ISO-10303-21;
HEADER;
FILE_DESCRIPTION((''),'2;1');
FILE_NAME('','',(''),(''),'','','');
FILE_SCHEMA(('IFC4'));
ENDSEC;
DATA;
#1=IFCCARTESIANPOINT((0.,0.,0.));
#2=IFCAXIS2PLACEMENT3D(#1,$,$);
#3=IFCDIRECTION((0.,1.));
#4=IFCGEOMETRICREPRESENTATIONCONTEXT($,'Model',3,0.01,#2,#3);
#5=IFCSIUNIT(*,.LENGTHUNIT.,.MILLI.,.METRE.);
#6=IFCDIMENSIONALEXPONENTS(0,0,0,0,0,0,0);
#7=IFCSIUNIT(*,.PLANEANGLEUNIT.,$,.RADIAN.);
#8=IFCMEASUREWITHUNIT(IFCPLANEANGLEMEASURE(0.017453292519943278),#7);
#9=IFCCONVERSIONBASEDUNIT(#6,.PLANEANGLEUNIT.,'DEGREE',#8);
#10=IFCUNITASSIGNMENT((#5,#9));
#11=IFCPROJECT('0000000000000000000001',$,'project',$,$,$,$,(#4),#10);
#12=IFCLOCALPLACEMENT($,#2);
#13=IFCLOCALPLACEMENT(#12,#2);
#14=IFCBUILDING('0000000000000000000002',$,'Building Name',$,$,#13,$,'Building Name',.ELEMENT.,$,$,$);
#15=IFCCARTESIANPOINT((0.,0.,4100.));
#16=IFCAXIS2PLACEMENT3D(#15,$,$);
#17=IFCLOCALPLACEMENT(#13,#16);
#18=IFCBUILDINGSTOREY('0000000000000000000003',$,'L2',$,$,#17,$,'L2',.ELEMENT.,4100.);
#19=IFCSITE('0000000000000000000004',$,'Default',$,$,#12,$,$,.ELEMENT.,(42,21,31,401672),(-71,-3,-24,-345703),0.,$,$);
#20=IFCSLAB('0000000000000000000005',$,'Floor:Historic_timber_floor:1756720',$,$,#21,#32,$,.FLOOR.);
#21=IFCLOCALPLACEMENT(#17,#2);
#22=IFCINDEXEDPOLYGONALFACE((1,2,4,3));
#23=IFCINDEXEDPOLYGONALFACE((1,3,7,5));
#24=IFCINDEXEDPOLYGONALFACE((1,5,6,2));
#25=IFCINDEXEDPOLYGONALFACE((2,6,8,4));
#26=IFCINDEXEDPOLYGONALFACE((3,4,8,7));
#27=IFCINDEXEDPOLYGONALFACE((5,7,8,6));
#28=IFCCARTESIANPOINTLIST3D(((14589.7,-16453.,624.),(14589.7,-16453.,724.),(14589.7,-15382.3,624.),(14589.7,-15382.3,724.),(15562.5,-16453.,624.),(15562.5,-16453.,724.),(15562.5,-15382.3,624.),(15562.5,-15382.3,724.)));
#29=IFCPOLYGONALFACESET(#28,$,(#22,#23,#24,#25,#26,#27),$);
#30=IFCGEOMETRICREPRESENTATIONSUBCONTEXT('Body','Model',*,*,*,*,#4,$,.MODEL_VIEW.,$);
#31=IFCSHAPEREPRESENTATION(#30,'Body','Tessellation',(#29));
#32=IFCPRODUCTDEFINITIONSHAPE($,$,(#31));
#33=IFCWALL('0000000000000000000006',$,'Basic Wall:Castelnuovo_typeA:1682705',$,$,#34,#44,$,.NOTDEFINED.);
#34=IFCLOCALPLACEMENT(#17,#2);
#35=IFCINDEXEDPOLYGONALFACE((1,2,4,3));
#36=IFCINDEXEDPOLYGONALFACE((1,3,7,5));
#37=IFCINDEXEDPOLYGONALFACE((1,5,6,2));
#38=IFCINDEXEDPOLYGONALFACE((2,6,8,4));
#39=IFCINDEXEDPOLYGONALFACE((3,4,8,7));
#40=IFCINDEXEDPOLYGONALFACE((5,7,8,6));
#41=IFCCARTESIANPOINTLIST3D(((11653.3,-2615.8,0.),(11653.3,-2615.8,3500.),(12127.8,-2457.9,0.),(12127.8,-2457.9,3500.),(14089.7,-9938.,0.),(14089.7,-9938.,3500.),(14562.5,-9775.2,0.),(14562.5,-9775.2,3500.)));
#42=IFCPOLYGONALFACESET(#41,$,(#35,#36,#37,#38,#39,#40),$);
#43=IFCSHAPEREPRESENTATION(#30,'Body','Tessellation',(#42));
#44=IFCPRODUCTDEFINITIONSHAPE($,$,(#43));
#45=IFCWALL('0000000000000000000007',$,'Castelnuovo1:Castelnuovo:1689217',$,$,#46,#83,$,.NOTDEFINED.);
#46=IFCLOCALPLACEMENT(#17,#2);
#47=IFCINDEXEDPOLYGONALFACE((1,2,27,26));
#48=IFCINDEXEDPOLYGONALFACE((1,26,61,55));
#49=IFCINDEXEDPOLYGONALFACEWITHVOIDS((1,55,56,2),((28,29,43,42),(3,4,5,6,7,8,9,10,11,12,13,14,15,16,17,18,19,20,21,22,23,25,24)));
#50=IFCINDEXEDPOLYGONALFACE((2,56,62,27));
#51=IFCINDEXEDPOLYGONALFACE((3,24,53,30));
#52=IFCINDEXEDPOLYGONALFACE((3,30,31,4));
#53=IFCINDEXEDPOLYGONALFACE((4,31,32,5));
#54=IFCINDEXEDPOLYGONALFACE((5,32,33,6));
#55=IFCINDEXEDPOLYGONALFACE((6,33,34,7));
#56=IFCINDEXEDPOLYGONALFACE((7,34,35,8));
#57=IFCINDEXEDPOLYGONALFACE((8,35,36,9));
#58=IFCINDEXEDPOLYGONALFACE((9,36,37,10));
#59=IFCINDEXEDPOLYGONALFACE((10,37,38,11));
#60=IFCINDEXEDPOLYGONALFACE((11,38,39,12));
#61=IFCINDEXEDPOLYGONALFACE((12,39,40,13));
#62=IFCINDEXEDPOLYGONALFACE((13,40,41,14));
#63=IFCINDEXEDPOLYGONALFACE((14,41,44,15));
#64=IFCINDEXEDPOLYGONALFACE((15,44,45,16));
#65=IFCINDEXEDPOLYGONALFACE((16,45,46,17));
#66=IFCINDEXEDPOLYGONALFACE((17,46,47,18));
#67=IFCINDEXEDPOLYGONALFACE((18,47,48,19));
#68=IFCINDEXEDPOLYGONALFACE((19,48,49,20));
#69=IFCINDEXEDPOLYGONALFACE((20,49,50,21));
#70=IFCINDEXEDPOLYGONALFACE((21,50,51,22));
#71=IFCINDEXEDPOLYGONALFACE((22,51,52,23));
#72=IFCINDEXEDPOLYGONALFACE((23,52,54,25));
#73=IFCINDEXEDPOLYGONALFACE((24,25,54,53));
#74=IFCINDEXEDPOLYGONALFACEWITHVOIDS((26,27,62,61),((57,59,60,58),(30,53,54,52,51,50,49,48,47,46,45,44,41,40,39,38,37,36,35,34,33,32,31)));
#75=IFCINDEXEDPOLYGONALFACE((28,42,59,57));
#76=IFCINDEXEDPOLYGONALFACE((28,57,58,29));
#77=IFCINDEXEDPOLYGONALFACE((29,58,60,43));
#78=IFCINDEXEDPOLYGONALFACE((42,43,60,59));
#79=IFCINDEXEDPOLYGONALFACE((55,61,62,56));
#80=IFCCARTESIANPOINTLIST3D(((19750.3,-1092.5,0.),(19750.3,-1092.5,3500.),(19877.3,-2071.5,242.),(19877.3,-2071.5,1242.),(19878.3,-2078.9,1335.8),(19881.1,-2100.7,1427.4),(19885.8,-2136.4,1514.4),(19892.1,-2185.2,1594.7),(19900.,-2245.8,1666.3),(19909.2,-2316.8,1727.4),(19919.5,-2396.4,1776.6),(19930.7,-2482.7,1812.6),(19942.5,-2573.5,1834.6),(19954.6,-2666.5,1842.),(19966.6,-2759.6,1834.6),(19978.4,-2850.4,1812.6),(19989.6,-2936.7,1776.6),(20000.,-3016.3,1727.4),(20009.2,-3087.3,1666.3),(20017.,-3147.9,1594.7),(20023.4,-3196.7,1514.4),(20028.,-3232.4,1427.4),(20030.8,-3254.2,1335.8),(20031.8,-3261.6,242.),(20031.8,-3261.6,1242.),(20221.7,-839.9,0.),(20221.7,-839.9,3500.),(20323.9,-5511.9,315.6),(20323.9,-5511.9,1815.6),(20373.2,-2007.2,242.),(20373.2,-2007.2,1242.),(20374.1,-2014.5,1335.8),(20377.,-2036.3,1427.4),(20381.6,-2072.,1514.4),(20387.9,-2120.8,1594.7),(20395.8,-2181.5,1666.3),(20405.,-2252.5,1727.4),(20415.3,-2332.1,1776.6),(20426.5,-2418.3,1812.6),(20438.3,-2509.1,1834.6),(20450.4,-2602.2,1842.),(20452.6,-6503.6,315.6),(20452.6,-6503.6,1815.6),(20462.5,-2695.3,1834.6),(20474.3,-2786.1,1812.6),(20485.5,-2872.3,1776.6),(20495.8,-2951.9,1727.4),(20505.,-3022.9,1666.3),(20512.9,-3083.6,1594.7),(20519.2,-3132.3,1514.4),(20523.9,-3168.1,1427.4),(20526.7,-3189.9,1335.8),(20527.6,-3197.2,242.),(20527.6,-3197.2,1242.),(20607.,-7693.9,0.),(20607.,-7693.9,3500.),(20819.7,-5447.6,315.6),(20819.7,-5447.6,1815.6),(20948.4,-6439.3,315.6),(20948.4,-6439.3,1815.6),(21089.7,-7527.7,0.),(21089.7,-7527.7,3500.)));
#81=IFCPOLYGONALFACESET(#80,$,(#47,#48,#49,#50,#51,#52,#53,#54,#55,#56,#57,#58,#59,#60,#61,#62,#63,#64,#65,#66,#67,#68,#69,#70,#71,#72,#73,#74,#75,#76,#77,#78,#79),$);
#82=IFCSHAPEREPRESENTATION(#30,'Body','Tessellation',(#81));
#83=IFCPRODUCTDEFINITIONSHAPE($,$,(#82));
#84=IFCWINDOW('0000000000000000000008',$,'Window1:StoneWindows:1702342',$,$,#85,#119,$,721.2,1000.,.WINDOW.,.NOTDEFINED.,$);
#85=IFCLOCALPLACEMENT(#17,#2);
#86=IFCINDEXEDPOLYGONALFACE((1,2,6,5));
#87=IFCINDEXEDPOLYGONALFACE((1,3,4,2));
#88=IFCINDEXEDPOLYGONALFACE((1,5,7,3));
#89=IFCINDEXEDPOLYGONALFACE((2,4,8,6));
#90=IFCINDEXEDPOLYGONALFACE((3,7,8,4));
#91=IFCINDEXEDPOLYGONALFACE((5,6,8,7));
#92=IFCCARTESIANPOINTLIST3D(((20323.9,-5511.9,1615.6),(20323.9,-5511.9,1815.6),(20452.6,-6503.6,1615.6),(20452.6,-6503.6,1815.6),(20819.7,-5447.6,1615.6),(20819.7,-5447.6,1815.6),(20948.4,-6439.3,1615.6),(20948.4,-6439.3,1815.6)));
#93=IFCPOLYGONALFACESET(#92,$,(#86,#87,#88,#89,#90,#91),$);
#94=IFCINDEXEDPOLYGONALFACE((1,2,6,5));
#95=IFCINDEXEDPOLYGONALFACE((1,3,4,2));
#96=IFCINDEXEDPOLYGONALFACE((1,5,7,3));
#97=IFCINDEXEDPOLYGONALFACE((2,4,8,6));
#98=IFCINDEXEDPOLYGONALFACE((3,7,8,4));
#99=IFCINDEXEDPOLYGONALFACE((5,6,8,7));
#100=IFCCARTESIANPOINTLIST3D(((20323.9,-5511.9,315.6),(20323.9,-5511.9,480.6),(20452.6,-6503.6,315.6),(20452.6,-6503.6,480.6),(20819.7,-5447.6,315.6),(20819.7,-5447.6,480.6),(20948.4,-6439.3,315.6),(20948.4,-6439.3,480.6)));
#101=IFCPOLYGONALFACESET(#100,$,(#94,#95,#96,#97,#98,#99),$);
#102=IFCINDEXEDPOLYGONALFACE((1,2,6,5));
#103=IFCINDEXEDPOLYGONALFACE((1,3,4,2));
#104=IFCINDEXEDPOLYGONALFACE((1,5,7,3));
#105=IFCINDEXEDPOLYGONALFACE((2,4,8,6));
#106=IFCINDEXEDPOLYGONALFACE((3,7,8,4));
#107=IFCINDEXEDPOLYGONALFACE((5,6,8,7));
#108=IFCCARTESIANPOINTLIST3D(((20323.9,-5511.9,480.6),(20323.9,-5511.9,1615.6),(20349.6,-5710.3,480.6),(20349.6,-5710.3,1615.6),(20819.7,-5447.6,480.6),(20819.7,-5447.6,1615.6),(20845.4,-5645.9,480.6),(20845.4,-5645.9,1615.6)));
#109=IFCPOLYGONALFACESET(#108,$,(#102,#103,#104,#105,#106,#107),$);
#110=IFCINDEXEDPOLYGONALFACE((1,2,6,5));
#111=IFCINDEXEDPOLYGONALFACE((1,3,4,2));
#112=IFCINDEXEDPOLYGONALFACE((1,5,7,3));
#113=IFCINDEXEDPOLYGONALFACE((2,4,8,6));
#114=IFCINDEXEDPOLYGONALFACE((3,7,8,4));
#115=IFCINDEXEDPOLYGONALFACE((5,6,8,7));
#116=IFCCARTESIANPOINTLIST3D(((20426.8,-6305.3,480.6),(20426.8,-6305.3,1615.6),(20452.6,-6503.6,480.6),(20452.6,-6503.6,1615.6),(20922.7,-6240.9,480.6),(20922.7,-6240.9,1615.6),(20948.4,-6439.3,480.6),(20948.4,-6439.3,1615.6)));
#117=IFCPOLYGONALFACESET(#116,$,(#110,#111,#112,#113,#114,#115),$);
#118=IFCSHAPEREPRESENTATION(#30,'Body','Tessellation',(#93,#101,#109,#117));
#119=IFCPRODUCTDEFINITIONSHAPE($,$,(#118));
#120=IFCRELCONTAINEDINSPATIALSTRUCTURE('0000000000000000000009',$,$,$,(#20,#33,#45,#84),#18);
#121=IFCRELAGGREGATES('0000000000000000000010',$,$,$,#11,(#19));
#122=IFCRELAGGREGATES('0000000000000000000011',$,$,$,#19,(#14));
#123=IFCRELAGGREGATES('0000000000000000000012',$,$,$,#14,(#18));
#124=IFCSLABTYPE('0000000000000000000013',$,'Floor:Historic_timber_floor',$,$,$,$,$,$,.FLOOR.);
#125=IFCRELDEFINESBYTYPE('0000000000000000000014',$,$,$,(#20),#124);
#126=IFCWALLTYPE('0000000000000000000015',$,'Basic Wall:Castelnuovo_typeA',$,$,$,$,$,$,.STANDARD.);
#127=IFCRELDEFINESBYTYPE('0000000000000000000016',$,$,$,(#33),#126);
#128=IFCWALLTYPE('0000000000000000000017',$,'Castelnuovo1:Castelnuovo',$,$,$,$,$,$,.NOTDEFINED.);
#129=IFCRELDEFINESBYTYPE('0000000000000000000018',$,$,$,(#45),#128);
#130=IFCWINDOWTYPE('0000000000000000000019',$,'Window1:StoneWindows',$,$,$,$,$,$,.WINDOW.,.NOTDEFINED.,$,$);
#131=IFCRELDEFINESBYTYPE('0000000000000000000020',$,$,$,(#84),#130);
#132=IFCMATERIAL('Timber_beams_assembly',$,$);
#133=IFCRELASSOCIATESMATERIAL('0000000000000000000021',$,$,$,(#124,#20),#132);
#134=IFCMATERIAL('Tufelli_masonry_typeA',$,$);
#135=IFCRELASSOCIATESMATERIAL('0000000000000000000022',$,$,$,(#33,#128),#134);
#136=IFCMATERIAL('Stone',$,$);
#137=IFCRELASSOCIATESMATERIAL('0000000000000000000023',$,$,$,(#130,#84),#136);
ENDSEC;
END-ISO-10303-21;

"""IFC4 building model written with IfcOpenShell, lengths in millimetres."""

from ifc_helpers import new_model, entity, si_unit, converted_unit, direction, frame, origin, place, context, subcontext, project, spatial, line, arc, indexed_curve, outline, extrude, source, transform, mapped, material, type_object, type_shapes, element, save


model = new_model("IFC4")

# Units and contexts
model_context = context("Model", 3, precision=0.01, world=origin(), true_north=direction((0.0, 1.0)))
body_context = subcontext(model_context, "Body", "Model", "MODEL_VIEW")
ifc_project = project(units=[si_unit("LENGTHUNIT", "METRE", prefix="MILLI"), converted_unit("PLANEANGLEUNIT", "DEGREE", entity("IfcPlaneAngleMeasure", 0.017453292519943278), si_unit("PLANEANGLEUNIT", "RADIAN"), dimensions=[0, 0, 0, 0, 0, 0, 0])], contexts=[model_context])

# Site, building, storey
site_placement = place(None, origin())
site = spatial("IfcSite", under=ifc_project, at=site_placement, Name="Default", CompositionType="ELEMENT", RefLatitude=(42, 21, 31, 401672), RefLongitude=(-71, -3, -24, -345703), RefElevation=0.0)
building_placement = place(site_placement, origin())
building = spatial("IfcBuilding", under=site, at=building_placement, Name="Building Name", LongName="Building Name", CompositionType="ELEMENT")
storey_placement = place(building_placement, frame((0.0, 0.0, 4100.0)))
storey = spatial("IfcBuildingStorey", under=building, at=storey_placement, Name="L2", LongName="L2", CompositionType="ELEMENT", Elevation=4100.0)

# Slab
ifc_material_1 = material(Name="Timber_beams_assembly")
slab_type = type_object("IfcSlabType", Name="Floor:Historic_timber_floor", PredefinedType="FLOOR", material=ifc_material_1)
slab_1_placement = place(storey_placement, origin())
element("IfcSlab", 1, at=slab_1_placement, inside=storey, type_object=slab_type, material=ifc_material_1, Name="Floor:Historic_timber_floor:1756720", PredefinedType="FLOOR", context=body_context, shape_type="SweptSolid", body=[
    extrude(outline(indexed_curve([(-535.3, -486.4), (535.3, -486.4), (535.3, 486.4), (-535.3, 486.4), (-535.3, -486.4)], self_intersect=False)), frame((15076.1, -15917.7, 724.0), z_axis=(0.0, 0.0, -1.0), x_axis=(0.0, 1.0, 0.0)), (0.0, 0.0, 1.0), 100.0),
])

# Wall
ifc_material_2 = material(Name="Tufelli_masonry_typeA")
wall_type_1 = type_object("IfcWallType", Name="Basic Wall:Castelnuovo_typeA", PredefinedType="STANDARD")
wall_1_placement = place(storey_placement, frame((11890.5, -2536.8, 0.0), z_axis=(0.0, 0.0, 1.0), x_axis=(0.315716, -0.948854, 0.0)))
element("IfcWall", 2, at=wall_1_placement, inside=storey, type_object=wall_type_1, material=ifc_material_2, Name="Basic Wall:Castelnuovo_typeA:1682705", PredefinedType="NOTDEFINED", context=body_context, shape_type="SweptSolid", body=[
    extrude(outline(indexed_curve([(7716.9, -250.0), (7711.7, 250.0), (0.0, 250.0), (0.0, -250.0), (7716.9, -250.0)], self_intersect=False)), origin(), (0.0, 0.0, 1.0), 3500.0),
])

# Wall, openings
wall_type_2 = type_object("IfcWallType", Name="Castelnuovo1:Castelnuovo", PredefinedType="NOTDEFINED", material=ifc_material_2)
wall_2_placement = place(storey_placement, frame((19750.3, -7693.9, 0.0), z_axis=(0.0, 0.0, 1.0), x_axis=(0.0, 1.0, 0.0)))
wall_2 = element("IfcWall", 3, at=wall_2_placement, inside=storey, type_object=wall_type_2, Name="Castelnuovo1:Castelnuovo:1689217", PredefinedType="NOTDEFINED", context=body_context, shape_type="SweptSolid", body=[
    extrude(outline(indexed_curve([(-929.1, -3281.7), (-418.7, -3281.7), (937.9, 3324.4), (409.9, 3239.0), (-929.1, -3281.7)], self_intersect=False)), frame((3405.4, -666.9, 0.0), z_axis=(0.0, 0.0, 1.0), x_axis=(0.325568, -0.945519, 0.0)), (0.0, 0.0, 1.0), 3500.0),
])
opening_1_placement = place(wall_2_placement, origin())
element("IfcOpeningElement", 4, at=opening_1_placement, cuts=wall_2, PredefinedType="OPENING", context=body_context, shape_type="SweptSolid", body=[
    extrude(outline(indexed_curve([(-750.0, -500.0), (750.0, -500.0), (750.0, 500.0), (-750.0, 500.0), (-750.0, -500.0)], self_intersect=False)), frame((1683.5, -618.1, 1065.6), z_axis=(0.128709, -0.991682, 0.0), x_axis=(0.0, 0.0, 1.0)), (0.0, 0.0, 1.0), 590.0),
])
opening_2_placement = place(wall_2_placement, origin())
element("IfcOpeningElement", 5, at=opening_2_placement, cuts=wall_2, PredefinedType="OPENING", context=body_context, shape_type="SweptSolid", body=[
    extrude(outline(indexed_curve([(-750.0, -500.0), (750.0, -500.0), (750.0, 500.0), (-750.0, 500.0), (-750.0, -500.0)], self_intersect=False)), frame((1753.0, -1153.6, 1065.6), z_axis=(-0.128709, 0.991682, 0.0), x_axis=(0.0, 0.0, 1.0)), (0.0, 0.0, 1.0), 590.0),
])
opening_3_placement = place(wall_2_placement, origin())
element("IfcOpeningElement", 6, at=opening_3_placement, cuts=wall_2, PredefinedType="OPENING", context=body_context, shape_type="SweptSolid", body=[
    extrude(outline(indexed_curve([(-750.0, -500.0), (750.0, -500.0), (750.0, 500.0), (-750.0, 500.0), (-750.0, -500.0)], self_intersect=False)), frame((1683.5, -618.1, 1065.6), z_axis=(0.128709, -0.991682, 0.0), x_axis=(0.0, 0.0, 1.0)), (0.0, 0.0, 1.0), 590.0),
])
opening_4_placement = place(wall_2_placement, origin())
element("IfcOpeningElement", 7, at=opening_4_placement, cuts=wall_2, PredefinedType="OPENING", context=body_context, shape_type="SweptSolid", body=[
    extrude(outline(indexed_curve([(-500.0, -600.0), (500.0, -600.0), (1100.0, 0.0), (500.0, 600.0), (-500.0, 600.0)], segments=[line(1, 2), arc(2, 3, 4), line(4, 5, 1)], self_intersect=False)), frame((5024.7, -184.5, 742.0), z_axis=(0.128709, -0.991682, 0.0), x_axis=(0.0, 0.0, 1.0)), (0.0, 0.0, 1.0), 590.0),
])

# Window
ifc_material_3 = material(Name="Stone")
window_type_1 = type_object("IfcWindowType", Name="Window1:StoneWindows", PartitioningType="NOTDEFINED", PredefinedType="WINDOW", material=ifc_material_3)
shared_shape_1 = source(origin(), body_context, "Body", "SweptSolid", [
    extrude(outline(indexed_curve([(-250.0, -500.0), (250.0, -500.0), (250.0, 500.0), (-250.0, 500.0), (-250.0, -500.0)], self_intersect=False)), frame((0.0, 0.0, 2100.0), z_axis=(0.0, 0.0, 1.0), x_axis=(0.0, 1.0, 0.0)), (0.0, 0.0, 1.0), 200.0),
    extrude(outline(indexed_curve([(-250.0, -500.0), (250.0, -500.0), (250.0, 500.0), (-250.0, 500.0), (-250.0, -500.0)], self_intersect=False)), frame((0.0, 0.0, 800.0), z_axis=(0.0, 0.0, 1.0), x_axis=(0.0, 1.0, 0.0)), (0.0, 0.0, 1.0), 165.0),
    extrude(outline(indexed_curve([(-250.0, -100.0), (250.0, -100.0), (250.0, 100.0), (-250.0, 100.0), (-250.0, -100.0)], self_intersect=False)), frame((-400.0, 0.0, 965.0), z_axis=(0.0, 0.0, 1.0), x_axis=(0.0, 1.0, 0.0)), (0.0, 0.0, 1.0), 1135.0),
    extrude(outline(indexed_curve([(-250.0, -100.0), (250.0, -100.0), (250.0, 100.0), (-250.0, 100.0), (-250.0, -100.0)], self_intersect=False)), frame((400.0, 0.0, 965.0), z_axis=(0.0, 0.0, 1.0), x_axis=(0.0, 1.0, 0.0)), (0.0, 0.0, 1.0), 1135.0),
])
type_shapes(window_type_1, [shared_shape_1])
for number, where, z_axis, x_axis, name in (
    (8, (20636.1, -5975.6, -484.4), (0.0, 0.0, 1.0), (0.128709, -0.991682, 0.0), "Window1:StoneWindows:1702342"),
):
    element("IfcWindow", number, at=place(storey_placement, frame(where, z_axis=z_axis, x_axis=x_axis)), inside=storey, type_object=window_type_1, material=ifc_material_3, Name=name, OverallHeight=721.2, OverallWidth=1000.0, PartitioningType="NOTDEFINED", PredefinedType="WINDOW", context=body_context, shape_type="MappedRepresentation", body=[
        mapped(shared_shape_1, transform((0.0, 0.0, 0.0), scale=1.0)),
    ])

save(model, "model.ifc")
